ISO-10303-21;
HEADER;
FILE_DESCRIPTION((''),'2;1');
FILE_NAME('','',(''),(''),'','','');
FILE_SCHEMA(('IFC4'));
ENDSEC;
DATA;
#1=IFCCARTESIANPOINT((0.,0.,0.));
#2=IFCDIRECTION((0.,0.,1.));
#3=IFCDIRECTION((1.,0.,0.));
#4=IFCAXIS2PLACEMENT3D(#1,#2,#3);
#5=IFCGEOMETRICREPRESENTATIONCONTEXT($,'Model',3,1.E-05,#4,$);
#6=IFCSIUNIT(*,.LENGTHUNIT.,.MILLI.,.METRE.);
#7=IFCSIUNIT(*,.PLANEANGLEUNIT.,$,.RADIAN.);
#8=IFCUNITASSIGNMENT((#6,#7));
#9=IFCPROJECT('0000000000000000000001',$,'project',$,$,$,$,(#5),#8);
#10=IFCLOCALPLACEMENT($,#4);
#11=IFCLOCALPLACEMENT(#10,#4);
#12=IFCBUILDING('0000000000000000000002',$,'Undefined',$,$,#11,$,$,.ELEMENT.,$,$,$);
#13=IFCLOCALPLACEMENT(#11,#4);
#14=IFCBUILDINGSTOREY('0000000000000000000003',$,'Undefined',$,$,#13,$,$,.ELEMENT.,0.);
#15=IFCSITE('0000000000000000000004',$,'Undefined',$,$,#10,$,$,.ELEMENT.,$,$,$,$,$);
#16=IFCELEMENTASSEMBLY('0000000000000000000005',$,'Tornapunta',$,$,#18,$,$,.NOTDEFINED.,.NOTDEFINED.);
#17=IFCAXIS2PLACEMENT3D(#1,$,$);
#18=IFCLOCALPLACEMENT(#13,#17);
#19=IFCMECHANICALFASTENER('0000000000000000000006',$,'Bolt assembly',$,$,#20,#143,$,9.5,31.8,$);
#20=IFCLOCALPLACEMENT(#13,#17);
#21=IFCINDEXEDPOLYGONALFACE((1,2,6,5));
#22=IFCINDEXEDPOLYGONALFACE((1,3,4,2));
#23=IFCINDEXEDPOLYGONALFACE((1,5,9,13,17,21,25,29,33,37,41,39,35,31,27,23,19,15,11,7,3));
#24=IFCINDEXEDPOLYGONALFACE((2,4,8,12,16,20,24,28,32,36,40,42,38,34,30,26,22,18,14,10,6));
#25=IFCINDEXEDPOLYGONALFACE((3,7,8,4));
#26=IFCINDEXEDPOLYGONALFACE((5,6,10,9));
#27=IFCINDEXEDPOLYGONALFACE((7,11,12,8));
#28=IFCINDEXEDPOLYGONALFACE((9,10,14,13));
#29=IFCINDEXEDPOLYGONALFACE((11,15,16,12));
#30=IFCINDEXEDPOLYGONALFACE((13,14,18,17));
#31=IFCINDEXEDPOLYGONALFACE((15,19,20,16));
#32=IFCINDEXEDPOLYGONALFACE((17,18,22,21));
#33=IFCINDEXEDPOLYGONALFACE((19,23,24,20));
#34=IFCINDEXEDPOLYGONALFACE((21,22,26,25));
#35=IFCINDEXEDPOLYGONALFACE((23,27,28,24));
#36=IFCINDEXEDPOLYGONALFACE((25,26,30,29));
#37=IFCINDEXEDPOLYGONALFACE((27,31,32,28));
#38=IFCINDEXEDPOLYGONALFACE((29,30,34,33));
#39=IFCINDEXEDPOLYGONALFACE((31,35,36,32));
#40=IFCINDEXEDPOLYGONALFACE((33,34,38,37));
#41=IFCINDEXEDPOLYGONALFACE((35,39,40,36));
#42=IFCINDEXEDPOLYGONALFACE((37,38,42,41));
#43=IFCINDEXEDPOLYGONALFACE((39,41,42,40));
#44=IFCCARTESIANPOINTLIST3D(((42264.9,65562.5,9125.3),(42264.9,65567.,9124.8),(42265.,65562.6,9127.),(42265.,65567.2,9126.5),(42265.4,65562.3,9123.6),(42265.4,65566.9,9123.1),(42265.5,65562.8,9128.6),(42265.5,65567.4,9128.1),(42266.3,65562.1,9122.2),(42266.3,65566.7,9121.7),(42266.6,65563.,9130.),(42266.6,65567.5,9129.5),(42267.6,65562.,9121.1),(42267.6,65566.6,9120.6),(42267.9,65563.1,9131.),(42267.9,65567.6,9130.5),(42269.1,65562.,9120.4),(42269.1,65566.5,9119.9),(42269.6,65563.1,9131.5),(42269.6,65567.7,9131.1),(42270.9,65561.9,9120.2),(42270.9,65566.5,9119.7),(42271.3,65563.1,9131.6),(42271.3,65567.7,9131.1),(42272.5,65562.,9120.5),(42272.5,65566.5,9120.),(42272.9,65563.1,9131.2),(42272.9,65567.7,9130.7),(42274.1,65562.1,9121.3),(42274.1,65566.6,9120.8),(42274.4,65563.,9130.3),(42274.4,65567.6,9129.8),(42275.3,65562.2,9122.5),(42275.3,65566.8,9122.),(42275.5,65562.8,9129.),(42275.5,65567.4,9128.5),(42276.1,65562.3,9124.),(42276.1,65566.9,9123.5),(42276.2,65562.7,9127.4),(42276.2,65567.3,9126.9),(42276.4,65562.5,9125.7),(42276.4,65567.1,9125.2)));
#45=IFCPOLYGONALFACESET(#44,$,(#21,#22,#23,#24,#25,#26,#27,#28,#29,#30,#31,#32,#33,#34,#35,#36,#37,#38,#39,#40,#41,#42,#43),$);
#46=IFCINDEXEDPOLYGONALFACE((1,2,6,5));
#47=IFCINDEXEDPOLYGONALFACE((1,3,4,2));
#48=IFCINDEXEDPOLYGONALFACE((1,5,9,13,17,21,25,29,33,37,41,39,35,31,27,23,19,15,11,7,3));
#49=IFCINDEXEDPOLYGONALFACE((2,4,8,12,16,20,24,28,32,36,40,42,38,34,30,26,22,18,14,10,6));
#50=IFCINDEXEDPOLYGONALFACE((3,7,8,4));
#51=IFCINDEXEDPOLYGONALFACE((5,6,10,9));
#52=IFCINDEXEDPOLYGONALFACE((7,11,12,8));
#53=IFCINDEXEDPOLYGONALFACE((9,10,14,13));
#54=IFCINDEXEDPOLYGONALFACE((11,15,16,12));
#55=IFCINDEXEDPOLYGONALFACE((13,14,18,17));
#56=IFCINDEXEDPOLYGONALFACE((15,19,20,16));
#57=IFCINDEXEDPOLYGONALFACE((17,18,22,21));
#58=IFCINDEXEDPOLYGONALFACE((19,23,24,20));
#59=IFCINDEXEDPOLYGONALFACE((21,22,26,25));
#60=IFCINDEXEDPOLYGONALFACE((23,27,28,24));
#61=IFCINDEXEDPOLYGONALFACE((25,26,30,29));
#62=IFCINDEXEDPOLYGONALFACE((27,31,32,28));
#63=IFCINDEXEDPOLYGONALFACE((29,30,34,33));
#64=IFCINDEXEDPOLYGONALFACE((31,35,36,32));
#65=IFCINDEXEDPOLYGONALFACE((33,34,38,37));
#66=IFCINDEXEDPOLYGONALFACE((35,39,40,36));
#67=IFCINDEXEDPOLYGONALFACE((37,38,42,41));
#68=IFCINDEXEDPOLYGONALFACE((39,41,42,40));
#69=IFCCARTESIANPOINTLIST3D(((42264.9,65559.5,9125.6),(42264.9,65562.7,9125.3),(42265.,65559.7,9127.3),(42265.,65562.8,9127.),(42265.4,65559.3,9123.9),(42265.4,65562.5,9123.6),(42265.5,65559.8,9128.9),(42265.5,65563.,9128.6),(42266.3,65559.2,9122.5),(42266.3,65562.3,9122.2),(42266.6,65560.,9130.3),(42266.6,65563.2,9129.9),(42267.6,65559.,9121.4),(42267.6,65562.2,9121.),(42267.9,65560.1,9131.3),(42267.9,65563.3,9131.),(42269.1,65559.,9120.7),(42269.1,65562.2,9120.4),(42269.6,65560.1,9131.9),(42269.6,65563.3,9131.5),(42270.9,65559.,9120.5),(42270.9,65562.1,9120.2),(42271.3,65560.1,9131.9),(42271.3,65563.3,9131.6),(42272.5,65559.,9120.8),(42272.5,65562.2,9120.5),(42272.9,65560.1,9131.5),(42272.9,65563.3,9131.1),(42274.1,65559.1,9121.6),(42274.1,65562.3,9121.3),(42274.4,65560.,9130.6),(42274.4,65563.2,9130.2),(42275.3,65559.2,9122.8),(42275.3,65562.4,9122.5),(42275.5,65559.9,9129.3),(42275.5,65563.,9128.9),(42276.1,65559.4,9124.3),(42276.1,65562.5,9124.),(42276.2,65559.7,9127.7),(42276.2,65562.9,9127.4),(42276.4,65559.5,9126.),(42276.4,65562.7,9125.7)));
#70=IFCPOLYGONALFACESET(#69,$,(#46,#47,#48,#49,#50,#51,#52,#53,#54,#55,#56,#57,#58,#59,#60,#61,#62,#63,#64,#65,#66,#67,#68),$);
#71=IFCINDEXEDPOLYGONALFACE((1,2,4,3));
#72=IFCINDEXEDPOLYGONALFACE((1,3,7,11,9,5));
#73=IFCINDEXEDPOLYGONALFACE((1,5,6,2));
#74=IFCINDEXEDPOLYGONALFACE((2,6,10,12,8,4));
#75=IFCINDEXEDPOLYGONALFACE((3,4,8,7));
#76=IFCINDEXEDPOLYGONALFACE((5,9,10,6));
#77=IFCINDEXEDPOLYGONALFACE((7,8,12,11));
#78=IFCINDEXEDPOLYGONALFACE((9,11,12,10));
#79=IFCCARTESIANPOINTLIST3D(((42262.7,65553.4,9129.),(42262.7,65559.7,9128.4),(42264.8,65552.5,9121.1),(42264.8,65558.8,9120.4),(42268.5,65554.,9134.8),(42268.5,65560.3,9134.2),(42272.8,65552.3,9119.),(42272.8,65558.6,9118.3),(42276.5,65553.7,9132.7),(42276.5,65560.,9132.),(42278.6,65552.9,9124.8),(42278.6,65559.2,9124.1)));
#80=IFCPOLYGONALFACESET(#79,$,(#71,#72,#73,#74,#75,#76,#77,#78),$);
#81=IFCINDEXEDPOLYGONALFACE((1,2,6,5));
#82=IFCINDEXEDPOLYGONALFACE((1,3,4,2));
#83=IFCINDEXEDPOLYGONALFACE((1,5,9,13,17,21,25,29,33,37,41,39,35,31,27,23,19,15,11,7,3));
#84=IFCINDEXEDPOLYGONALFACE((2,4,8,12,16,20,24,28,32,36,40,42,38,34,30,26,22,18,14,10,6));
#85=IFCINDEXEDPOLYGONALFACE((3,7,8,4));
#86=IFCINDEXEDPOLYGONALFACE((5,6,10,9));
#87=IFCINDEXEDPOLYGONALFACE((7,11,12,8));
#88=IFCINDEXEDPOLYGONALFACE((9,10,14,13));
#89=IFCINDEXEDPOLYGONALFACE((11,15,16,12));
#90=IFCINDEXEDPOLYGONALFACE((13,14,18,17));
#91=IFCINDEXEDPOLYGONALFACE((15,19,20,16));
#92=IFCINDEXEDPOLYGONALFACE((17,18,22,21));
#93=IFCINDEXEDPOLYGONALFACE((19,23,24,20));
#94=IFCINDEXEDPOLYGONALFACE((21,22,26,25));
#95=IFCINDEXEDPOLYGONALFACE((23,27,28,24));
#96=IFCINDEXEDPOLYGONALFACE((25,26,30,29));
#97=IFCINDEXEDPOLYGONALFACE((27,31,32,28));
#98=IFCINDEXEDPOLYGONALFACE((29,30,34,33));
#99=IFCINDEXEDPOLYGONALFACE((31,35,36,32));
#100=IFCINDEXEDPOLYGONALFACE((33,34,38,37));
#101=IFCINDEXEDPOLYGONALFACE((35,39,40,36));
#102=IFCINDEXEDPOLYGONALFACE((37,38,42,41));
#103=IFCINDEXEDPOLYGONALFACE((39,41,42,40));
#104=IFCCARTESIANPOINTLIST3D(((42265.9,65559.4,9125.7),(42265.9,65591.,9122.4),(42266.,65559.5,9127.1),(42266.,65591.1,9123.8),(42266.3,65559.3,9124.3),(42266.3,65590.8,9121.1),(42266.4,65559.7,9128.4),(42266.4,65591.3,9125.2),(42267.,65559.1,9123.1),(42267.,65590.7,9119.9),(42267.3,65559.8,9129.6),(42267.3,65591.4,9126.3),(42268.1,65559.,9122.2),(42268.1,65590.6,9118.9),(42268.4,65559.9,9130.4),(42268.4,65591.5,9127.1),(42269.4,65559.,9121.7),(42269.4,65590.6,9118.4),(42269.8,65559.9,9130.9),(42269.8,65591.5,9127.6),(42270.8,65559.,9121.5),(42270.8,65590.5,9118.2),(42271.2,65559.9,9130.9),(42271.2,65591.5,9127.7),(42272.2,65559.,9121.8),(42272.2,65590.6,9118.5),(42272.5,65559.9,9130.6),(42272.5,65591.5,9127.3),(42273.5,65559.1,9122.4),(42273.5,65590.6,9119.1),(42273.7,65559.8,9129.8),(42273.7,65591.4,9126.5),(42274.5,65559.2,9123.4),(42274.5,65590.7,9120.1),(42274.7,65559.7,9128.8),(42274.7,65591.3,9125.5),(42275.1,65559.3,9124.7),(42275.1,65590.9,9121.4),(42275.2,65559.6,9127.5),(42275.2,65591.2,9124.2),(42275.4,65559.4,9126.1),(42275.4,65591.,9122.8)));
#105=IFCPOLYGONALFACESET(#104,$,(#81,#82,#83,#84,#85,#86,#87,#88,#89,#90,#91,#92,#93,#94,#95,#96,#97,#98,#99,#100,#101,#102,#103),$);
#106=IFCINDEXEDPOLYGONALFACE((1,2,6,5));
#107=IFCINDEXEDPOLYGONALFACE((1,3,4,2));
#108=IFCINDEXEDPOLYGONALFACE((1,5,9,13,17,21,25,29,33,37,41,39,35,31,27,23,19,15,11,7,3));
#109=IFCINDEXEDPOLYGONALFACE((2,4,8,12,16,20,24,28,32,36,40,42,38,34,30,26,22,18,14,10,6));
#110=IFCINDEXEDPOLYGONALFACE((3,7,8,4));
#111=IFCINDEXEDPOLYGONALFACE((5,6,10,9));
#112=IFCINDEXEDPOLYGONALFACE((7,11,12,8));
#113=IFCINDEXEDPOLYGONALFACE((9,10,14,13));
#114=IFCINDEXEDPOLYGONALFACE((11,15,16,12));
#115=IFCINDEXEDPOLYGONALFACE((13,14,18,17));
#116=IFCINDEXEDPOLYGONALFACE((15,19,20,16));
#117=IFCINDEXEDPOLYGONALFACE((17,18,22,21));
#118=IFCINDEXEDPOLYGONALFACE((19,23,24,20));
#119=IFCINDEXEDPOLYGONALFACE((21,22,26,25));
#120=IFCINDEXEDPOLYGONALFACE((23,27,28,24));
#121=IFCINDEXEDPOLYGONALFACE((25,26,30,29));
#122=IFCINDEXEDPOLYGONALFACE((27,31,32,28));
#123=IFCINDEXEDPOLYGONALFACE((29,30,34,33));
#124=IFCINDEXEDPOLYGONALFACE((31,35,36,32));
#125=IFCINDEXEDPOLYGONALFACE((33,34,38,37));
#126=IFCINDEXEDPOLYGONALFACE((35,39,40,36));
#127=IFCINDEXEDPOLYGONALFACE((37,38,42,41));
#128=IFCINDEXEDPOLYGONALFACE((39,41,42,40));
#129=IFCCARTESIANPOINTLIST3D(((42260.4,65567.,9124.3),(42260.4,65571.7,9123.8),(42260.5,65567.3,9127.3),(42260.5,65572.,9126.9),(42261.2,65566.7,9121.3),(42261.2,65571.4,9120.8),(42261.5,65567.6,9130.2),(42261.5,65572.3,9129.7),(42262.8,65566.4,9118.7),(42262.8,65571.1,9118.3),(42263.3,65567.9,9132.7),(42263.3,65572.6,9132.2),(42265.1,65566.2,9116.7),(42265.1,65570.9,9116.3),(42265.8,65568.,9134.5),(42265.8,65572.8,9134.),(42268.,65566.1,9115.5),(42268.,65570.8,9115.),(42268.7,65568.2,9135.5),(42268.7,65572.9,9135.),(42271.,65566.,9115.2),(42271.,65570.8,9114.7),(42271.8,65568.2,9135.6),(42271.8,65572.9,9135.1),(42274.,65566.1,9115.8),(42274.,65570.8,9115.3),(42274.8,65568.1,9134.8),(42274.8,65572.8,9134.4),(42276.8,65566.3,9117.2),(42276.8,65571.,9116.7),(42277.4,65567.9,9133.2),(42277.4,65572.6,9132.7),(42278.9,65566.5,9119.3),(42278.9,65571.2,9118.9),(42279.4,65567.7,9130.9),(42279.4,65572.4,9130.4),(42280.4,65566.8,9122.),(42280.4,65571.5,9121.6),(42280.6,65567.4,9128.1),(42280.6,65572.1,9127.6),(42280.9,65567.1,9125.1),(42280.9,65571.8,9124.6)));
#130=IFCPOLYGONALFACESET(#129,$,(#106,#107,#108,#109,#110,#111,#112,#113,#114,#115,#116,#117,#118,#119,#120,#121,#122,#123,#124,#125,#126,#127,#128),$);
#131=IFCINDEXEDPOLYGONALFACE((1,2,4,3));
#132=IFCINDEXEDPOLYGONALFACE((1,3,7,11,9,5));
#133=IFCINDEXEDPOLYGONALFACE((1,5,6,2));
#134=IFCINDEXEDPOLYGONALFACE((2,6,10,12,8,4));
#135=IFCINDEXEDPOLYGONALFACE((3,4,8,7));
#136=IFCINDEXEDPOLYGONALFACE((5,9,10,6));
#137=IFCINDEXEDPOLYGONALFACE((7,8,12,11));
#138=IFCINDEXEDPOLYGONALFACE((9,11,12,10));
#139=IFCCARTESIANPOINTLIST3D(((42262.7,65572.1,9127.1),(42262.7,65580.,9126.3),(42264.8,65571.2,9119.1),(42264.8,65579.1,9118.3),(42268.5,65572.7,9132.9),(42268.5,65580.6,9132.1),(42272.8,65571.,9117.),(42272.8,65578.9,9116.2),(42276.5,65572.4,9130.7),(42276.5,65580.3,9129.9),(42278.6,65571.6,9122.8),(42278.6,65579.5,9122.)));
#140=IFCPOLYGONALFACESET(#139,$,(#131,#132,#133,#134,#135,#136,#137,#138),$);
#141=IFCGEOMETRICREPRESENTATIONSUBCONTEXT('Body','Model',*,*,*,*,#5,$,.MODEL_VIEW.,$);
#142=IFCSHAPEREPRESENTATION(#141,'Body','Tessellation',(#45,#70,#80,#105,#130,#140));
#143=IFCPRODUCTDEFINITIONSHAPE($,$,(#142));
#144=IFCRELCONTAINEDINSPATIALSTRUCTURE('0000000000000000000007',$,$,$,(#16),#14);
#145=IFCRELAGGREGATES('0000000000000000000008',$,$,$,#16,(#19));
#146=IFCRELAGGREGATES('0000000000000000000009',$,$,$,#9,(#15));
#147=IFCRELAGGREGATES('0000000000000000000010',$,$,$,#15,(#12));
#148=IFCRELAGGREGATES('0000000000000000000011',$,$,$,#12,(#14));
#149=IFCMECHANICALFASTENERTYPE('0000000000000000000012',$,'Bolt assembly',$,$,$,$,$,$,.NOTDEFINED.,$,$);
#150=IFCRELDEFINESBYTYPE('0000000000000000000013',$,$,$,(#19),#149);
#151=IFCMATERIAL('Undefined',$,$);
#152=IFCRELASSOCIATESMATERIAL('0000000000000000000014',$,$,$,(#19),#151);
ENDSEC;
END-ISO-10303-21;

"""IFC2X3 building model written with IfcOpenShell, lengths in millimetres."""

from ifc_helpers import new_model, si_unit, frame, origin_with_axes, origin_2d_with_axis, place, context, subcontext, project, spatial, polyline, circle, outline, extrude, source, transform, mapped, material, type_object, element, aggregate, save


model = new_model("IFC2X3")

# Units and contexts
model_context = context("Model", 3, precision=1e-05, world=origin_with_axes())
body_context = subcontext(model_context, "Body", "Model", "MODEL_VIEW")
ifc_project = project(units=[si_unit("LENGTHUNIT", "METRE", prefix="MILLI"), si_unit("PLANEANGLEUNIT", "RADIAN")], contexts=[model_context])

# Site, building, storey
site_placement = place(None, origin_with_axes())
site = spatial("IfcSite", under=ifc_project, at=site_placement, Name="Undefined", CompositionType="ELEMENT")
building_placement = place(site_placement, origin_with_axes())
building = spatial("IfcBuilding", under=site, at=building_placement, Name="Undefined", CompositionType="ELEMENT")
storey_placement = place(building_placement, origin_with_axes())
storey = spatial("IfcBuildingStorey", under=building, at=storey_placement, Name="Undefined", CompositionType="ELEMENT", Elevation=0.0)

# Element assembly
assembly_1_placement = place(storey_placement, origin_with_axes())
assembly_1 = element("IfcElementAssembly", 1, at=assembly_1_placement, inside=storey, Name="Tornapunta", AssemblyPlace="NOTDEFINED", PredefinedType="NOTDEFINED")

# Shared definitions
ifc_material_1 = material(Name="Undefined")
mechanical_fastener_type = type_object("IfcMechanicalFastenerType", Name="Bolt assembly")

# Mechanical fastener
shared_shape_1 = source(origin_with_axes(), body_context, "Body", "SweptSolid", [
    extrude(circle(Radius=5.8, at=origin_2d_with_axis()), frame((0.0, -0.1, 0.0), z_axis=(0.0, 1.0, 0.0), x_axis=(1.0, 0.0, 0.0)), (0.0, 0.0, 1.0), 4.6),
    extrude(circle(Radius=5.8, at=origin_2d_with_axis()), frame((0.0, -3.1, 0.0), z_axis=(0.0, 1.0, 0.0), x_axis=(1.0, 0.0, 0.0)), (0.0, 0.0, 1.0), 3.2),
    extrude(outline(polyline([(7.1, -4.1), (7.1, 4.1), (0.0, 8.2), (-7.1, 4.1), (-7.1, -4.1), (0.0, -8.2), (7.1, -4.1)])), frame((0.0, -9.5, 0.0), z_axis=(0.0, 1.0, 0.0), x_axis=(1.0, 0.0, 0.0)), (0.0, 0.0, 1.0), 6.3),
    extrude(circle(Radius=4.8, at=origin_2d_with_axis()), frame((0.0, -3.2, 0.0), z_axis=(0.0, 1.0, 0.0), x_axis=(1.0, 0.0, 0.0)), (0.0, 0.0, 1.0), 31.8),
    extrude(circle(Radius=10.3, at=origin_2d_with_axis()), frame((0.0, 4.5, 0.0), z_axis=(0.0, 1.0, 0.0), x_axis=(1.0, 0.0, 0.0)), (0.0, 0.0, 1.0), 4.8),
    extrude(outline(polyline([(7.1, -4.1), (7.1, 4.1), (0.0, 8.2), (-7.1, 4.1), (-7.1, -4.1), (0.0, -8.2), (7.1, -4.1)])), frame((0.0, 9.3, 0.0), z_axis=(0.0, 1.0, 0.0), x_axis=(1.0, 0.0, 0.0)), (0.0, 0.0, 1.0), 7.9),
])
mechanical_fastener_1_placement = place(assembly_1_placement, frame((42270.6, 65562.6, 9125.9), z_axis=(-0.707107, -0.072947, -0.703334), x_axis=(-0.707107, 0.072947, 0.703334)))
mechanical_fastener_1 = element("IfcMechanicalFastener", 2, at=mechanical_fastener_1_placement, type_object=mechanical_fastener_type, material=ifc_material_1, Name="Bolt assembly", NominalDiameter=9.5, NominalLength=31.8, context=body_context, shape_type="MappedRepresentation", body=[
    mapped(shared_shape_1, transform((0.0, 0.0, 0.0))),
])
aggregate(assembly_1, [mechanical_fastener_1])

save(model, "model.ifc")
